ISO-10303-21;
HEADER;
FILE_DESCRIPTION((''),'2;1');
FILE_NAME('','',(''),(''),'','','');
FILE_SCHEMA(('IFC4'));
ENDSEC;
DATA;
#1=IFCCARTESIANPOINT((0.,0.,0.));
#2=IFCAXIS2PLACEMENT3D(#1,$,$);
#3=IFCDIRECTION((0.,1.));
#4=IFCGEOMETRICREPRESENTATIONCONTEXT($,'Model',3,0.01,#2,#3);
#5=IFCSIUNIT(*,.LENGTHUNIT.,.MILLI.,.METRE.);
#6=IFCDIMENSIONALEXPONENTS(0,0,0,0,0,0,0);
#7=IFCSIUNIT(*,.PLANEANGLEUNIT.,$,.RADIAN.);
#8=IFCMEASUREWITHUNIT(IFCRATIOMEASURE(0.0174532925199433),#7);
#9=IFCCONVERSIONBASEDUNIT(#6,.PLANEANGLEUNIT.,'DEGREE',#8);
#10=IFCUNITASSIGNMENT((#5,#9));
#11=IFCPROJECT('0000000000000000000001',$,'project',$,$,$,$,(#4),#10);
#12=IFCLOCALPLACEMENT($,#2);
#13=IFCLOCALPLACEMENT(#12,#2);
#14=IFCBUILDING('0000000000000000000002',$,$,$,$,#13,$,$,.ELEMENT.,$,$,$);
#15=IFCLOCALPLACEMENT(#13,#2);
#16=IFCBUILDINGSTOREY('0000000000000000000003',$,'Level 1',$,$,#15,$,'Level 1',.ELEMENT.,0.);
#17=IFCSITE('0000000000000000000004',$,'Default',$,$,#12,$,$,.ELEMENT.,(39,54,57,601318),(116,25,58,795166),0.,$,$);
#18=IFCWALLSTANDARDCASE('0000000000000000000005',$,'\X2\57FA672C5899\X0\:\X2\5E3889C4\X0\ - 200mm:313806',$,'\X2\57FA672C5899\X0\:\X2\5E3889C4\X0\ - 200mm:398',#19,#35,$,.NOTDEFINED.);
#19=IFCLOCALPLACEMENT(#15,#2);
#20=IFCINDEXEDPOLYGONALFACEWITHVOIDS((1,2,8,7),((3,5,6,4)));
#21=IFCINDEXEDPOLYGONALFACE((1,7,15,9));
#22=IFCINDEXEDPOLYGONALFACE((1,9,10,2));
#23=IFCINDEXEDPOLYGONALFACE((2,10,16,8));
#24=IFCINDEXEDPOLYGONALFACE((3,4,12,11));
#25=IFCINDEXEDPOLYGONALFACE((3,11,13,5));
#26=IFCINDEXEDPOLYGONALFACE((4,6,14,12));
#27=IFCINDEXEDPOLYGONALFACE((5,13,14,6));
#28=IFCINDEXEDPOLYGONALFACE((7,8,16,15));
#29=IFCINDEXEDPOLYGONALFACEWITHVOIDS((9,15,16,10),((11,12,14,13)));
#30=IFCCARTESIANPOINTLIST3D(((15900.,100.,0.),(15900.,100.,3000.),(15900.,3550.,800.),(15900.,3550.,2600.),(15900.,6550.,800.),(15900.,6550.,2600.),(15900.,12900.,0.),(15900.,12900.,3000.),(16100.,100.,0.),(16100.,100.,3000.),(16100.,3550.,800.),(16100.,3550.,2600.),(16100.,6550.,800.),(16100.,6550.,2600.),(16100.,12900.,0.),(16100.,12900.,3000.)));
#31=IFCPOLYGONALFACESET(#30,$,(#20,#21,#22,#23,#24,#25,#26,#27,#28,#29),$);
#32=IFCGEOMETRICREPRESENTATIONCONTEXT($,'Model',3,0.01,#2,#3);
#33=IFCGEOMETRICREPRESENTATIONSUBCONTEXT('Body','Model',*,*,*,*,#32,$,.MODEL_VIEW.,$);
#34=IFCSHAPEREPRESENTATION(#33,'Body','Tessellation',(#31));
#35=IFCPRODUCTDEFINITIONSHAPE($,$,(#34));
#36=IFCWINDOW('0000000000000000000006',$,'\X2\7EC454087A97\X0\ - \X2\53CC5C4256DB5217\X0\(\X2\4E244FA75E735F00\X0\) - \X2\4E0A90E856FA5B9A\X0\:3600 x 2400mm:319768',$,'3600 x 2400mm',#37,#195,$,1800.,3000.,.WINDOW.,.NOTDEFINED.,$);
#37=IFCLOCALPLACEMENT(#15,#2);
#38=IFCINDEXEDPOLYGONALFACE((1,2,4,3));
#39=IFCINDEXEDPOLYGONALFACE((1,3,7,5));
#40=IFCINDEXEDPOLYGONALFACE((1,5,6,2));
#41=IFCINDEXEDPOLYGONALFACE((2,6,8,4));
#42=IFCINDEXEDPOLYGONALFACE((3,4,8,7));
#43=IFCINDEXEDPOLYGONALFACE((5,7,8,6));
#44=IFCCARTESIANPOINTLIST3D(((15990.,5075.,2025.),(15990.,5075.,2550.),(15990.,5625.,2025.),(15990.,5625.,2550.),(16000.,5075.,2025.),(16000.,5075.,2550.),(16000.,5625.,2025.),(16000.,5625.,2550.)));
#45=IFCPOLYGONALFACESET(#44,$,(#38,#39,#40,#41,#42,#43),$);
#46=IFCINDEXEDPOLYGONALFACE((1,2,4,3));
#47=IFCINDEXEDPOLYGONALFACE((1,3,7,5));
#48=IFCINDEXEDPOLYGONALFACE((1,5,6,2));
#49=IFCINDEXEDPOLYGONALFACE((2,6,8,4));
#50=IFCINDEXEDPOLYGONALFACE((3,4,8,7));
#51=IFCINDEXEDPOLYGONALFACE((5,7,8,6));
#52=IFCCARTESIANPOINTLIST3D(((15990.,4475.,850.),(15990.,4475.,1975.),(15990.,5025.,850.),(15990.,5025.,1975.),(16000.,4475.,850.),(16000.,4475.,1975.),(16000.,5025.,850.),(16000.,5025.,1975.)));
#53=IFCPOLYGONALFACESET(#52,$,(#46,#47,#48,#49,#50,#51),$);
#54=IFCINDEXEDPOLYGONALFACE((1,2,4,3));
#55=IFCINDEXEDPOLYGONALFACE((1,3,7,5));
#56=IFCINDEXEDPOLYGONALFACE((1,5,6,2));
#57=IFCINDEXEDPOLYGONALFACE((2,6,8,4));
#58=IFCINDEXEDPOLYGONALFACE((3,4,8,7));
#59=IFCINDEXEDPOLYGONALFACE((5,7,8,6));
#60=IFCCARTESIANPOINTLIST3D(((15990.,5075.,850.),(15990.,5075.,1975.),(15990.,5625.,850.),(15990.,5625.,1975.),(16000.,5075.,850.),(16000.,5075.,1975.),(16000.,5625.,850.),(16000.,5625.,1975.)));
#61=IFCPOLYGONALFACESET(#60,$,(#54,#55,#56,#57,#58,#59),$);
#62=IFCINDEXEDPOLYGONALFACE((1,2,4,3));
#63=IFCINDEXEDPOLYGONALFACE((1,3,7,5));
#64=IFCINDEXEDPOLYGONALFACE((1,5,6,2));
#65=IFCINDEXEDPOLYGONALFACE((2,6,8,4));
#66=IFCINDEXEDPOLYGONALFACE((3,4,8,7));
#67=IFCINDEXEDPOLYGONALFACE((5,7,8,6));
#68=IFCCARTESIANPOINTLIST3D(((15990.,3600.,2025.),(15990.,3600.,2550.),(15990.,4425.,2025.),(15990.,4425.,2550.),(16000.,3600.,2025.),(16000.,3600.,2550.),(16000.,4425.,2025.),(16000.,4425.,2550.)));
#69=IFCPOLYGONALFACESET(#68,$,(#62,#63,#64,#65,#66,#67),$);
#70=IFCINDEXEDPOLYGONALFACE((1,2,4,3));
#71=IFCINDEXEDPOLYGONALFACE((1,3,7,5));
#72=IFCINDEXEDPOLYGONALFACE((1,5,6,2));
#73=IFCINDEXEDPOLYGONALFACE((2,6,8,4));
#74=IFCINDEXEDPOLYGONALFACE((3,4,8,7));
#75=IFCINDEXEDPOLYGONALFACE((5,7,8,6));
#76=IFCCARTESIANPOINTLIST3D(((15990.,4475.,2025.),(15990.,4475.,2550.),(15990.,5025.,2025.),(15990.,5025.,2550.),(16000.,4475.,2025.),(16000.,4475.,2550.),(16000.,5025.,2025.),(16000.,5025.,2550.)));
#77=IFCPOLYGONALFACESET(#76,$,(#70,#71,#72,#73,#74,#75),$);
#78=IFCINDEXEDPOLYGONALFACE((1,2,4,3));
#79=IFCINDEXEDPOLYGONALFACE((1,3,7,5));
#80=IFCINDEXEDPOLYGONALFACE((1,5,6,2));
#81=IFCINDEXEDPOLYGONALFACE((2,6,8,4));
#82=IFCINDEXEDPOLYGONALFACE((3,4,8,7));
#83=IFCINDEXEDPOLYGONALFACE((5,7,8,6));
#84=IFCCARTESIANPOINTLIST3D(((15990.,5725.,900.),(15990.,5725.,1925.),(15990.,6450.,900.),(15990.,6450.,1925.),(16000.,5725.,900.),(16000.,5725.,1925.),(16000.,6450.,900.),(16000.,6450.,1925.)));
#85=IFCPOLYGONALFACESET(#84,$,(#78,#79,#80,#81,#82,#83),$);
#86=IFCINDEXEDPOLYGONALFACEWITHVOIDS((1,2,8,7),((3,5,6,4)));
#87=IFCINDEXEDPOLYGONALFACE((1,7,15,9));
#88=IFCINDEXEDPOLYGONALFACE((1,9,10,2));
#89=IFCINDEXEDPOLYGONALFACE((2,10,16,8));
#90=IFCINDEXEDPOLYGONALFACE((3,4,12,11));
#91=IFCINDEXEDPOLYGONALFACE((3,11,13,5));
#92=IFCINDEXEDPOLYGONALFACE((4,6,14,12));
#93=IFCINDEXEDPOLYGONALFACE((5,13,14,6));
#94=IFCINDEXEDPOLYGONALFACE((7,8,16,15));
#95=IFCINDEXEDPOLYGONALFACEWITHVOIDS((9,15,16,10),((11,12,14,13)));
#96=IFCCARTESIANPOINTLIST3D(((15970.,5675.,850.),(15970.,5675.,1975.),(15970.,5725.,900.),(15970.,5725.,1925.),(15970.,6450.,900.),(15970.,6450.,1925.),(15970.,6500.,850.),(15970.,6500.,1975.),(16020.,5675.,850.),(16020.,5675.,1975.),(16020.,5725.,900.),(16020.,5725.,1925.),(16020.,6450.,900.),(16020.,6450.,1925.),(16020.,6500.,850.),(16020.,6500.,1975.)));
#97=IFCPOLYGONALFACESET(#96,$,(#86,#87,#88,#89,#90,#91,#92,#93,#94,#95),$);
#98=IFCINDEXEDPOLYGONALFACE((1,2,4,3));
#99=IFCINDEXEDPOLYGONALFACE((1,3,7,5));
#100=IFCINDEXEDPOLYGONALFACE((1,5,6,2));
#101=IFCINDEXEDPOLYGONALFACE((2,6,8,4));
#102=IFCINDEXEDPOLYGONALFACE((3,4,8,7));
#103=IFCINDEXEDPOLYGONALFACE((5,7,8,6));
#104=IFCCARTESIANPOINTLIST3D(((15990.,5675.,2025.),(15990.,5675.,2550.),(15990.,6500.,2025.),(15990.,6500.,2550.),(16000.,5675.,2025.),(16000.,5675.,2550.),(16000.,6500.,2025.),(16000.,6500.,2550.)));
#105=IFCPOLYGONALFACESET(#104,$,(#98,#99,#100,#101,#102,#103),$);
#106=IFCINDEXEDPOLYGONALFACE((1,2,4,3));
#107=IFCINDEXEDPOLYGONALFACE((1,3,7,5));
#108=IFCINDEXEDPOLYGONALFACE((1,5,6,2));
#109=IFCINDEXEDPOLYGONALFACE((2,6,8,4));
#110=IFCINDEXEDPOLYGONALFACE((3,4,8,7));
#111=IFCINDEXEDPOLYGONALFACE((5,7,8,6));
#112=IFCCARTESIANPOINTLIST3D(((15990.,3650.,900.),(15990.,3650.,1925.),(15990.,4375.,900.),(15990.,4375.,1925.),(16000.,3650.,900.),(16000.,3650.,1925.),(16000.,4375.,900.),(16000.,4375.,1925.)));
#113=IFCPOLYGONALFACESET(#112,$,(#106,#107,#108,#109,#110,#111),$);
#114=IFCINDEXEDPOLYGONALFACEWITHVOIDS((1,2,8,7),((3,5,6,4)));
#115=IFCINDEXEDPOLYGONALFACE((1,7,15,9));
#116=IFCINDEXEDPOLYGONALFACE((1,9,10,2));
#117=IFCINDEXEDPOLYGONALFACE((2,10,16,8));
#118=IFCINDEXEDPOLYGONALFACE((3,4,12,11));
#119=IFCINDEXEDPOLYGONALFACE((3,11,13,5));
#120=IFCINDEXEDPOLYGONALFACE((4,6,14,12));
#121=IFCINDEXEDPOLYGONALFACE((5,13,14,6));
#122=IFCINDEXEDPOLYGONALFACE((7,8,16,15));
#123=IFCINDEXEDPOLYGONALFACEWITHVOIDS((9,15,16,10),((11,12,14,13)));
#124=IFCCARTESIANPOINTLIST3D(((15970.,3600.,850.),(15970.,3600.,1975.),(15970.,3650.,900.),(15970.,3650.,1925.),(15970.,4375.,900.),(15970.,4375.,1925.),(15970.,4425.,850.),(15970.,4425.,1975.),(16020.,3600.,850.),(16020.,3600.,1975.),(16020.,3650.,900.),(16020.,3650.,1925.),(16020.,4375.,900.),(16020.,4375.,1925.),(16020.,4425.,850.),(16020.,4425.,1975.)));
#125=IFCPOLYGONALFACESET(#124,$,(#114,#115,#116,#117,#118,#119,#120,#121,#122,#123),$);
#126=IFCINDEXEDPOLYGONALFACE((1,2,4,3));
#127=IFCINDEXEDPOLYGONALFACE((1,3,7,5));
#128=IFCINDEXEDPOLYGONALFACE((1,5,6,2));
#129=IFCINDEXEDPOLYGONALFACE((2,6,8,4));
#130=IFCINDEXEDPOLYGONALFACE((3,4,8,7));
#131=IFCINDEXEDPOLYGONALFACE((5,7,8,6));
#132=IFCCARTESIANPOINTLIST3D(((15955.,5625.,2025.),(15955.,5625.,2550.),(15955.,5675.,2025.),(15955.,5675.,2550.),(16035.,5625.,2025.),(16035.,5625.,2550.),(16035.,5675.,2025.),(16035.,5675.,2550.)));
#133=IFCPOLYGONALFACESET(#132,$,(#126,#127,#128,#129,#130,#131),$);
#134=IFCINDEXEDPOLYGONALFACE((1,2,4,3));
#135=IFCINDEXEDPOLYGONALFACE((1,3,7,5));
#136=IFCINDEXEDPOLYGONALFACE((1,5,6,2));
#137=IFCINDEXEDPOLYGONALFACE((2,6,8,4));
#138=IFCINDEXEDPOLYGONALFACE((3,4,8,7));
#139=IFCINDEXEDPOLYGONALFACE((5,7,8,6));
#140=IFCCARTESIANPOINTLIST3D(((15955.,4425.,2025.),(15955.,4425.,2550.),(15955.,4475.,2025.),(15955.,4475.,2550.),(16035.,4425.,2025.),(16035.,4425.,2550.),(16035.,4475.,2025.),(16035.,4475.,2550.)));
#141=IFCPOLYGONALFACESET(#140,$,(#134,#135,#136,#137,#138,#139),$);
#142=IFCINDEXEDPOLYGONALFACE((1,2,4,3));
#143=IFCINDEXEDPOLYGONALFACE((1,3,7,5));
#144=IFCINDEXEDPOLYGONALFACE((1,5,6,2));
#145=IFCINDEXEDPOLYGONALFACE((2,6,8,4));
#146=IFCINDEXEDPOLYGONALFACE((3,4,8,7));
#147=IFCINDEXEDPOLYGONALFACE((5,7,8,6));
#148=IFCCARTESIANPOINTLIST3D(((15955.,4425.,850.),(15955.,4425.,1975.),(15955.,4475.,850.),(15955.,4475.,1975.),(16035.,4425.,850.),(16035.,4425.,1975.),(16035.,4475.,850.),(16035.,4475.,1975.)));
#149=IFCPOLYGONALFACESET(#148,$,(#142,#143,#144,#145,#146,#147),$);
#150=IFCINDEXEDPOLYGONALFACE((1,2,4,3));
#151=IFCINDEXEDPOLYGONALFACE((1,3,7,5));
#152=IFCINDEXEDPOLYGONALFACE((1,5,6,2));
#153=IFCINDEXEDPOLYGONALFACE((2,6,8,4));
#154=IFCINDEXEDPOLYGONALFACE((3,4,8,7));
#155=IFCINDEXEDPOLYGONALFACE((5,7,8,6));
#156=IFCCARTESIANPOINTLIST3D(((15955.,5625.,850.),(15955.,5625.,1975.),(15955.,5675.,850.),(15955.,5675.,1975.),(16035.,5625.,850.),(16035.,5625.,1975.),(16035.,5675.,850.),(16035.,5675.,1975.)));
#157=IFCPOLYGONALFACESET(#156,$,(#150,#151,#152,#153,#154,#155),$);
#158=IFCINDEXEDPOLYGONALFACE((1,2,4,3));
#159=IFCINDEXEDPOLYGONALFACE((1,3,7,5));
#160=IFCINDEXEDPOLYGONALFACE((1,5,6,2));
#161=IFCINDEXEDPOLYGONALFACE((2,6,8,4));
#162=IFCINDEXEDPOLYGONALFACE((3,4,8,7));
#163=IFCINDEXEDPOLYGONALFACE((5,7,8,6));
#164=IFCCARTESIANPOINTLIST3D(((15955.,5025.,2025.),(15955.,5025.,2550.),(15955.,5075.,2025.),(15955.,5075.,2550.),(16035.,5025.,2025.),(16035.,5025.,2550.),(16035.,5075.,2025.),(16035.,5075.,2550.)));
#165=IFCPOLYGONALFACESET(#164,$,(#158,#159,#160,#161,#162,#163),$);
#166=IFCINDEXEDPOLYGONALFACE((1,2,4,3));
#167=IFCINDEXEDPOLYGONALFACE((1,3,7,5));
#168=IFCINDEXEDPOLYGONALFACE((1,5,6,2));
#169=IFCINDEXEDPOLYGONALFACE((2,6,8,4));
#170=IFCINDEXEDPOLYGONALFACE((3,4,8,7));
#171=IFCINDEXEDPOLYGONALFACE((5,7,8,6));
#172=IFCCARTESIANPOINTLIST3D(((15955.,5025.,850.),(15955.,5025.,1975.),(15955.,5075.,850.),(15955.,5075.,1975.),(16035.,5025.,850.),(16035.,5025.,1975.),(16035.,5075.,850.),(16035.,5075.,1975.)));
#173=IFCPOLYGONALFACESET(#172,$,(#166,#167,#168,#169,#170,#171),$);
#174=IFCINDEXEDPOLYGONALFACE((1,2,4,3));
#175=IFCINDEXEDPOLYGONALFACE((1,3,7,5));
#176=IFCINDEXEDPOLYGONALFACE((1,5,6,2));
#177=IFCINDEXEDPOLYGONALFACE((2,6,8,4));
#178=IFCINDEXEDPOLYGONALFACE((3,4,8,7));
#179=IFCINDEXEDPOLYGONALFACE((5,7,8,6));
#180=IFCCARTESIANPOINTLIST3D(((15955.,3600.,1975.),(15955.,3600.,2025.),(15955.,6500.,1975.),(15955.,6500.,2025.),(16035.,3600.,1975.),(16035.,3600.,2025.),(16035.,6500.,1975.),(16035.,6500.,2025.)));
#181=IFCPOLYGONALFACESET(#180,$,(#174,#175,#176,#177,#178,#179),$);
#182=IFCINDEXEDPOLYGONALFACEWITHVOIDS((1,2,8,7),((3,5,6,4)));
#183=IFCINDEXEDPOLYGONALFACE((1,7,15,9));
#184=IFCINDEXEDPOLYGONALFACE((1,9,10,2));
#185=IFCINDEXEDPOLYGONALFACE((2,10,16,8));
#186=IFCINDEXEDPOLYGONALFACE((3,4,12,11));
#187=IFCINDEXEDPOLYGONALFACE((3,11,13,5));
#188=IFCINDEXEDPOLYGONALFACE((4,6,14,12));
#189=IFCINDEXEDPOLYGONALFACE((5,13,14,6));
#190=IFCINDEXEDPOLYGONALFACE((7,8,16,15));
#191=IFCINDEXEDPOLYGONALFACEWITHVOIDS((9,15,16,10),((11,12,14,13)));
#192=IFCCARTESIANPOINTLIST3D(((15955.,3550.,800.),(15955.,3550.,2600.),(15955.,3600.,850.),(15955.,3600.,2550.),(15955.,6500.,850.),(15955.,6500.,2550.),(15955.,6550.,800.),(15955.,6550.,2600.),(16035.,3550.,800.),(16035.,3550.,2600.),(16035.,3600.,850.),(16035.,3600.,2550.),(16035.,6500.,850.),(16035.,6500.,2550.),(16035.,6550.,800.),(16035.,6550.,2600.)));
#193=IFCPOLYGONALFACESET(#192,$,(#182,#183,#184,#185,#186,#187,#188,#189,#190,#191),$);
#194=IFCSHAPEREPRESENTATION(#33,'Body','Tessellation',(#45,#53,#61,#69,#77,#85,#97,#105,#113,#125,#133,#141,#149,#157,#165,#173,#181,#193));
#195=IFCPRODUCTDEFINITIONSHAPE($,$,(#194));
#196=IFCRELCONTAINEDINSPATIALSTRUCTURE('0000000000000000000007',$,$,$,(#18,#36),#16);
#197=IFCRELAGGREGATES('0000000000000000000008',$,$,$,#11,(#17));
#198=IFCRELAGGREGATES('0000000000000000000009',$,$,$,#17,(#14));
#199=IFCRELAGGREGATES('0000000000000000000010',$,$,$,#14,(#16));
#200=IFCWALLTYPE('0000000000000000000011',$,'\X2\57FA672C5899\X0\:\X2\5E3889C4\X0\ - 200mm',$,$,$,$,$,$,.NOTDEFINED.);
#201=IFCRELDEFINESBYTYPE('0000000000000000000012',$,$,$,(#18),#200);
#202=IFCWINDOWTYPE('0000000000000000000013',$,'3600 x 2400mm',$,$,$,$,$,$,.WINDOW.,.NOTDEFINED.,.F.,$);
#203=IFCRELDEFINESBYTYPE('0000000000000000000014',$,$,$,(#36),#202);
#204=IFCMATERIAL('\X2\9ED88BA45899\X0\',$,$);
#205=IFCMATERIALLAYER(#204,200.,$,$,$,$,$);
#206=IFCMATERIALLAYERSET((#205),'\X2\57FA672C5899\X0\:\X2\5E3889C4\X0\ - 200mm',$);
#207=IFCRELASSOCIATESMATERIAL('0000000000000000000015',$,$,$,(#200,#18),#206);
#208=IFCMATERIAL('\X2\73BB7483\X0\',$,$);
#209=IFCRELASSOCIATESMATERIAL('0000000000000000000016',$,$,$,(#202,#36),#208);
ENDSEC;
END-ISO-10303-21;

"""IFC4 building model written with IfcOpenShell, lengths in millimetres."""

from ifc_helpers import new_model, entity, si_unit, converted_unit, direction, frame, frame_2d, origin, origin_2d_with_axis, place, context, subcontext, project, spatial, polyline, rectangle, outline, extrude, source, transform, mapped, material, layer, layer_set, layer_usage, type_object, type_shapes, element, fill, save


model = new_model("IFC4")

# Units and contexts
model_context_1 = context("Model", 3, precision=0.01, world=origin(), true_north=direction((0.0, 1.0)))
model_context_2 = context("Model", 3, precision=0.01, world=origin(), true_north=direction((0.0, 1.0)))
body_context = subcontext(model_context_2, "Body", "Model", "MODEL_VIEW")
ifc_project = project(units=[si_unit("LENGTHUNIT", "METRE", prefix="MILLI"), converted_unit("PLANEANGLEUNIT", "DEGREE", entity("IfcRatioMeasure", 0.0174532925199433), si_unit("PLANEANGLEUNIT", "RADIAN"), dimensions=[0, 0, 0, 0, 0, 0, 0])], contexts=[model_context_1])

# Site, building, storey
site_placement = place(None, origin())
site = spatial("IfcSite", under=ifc_project, at=site_placement, Name="Default", CompositionType="ELEMENT", RefLatitude=(39, 54, 57, 601318), RefLongitude=(116, 25, 58, 795166), RefElevation=0.0)
building_placement = place(site_placement, origin())
building = spatial("IfcBuilding", under=site, at=building_placement, CompositionType="ELEMENT")
storey_placement = place(building_placement, origin())
storey = spatial("IfcBuildingStorey", under=building, at=storey_placement, Name="Level 1", LongName="Level 1", CompositionType="ELEMENT", Elevation=0.0)

# Shared definitions
ifc_material_1 = material(Name="默认墙")
ifc_layer = layer(ifc_material_1, 200.0)
ifc_layer_set = layer_set([ifc_layer], Name="基本墙:常规 - 200mm")
wall_type = type_object("IfcWallType", Name="基本墙:常规 - 200mm", PredefinedType="NOTDEFINED", material=ifc_layer_set)
ifc_material_2 = material(Name="玻璃")
window_type_1 = type_object("IfcWindowType", Name="3600 x 2400mm", ParameterTakesPrecedence=False, PartitioningType="NOTDEFINED", PredefinedType="WINDOW", material=ifc_material_2)
shared_shape_1 = source(origin(), body_context, "Body", "SweptSolid", [
    extrude(rectangle(XDim=10.0, YDim=550.0, at=origin_2d_with_axis()), frame((1200.0, 95.0, 1225.0), z_axis=(0.0, 0.0, 1.0), x_axis=(0.0, 1.0, 0.0)), (0.0, 0.0, 1.0), 525.0),
    extrude(rectangle(XDim=10.0, YDim=550.0, at=origin_2d_with_axis()), frame((1800.0, 95.0, 50.0), z_axis=(0.0, 0.0, 1.0), x_axis=(0.0, 1.0, 0.0)), (0.0, 0.0, 1.0), 1125.0),
    extrude(rectangle(XDim=10.0, YDim=550.0, at=origin_2d_with_axis()), frame((1200.0, 95.0, 50.0), z_axis=(0.0, 0.0, 1.0), x_axis=(0.0, 1.0, 0.0)), (0.0, 0.0, 1.0), 1125.0),
    extrude(rectangle(XDim=10.0, YDim=825.0, at=origin_2d_with_axis()), frame((2537.5, 95.0, 1225.0), z_axis=(0.0, 0.0, 1.0), x_axis=(0.0, 1.0, 0.0)), (0.0, 0.0, 1.0), 525.0),
    extrude(rectangle(XDim=10.0, YDim=550.0, at=origin_2d_with_axis()), frame((1800.0, 95.0, 1225.0), z_axis=(0.0, 0.0, 1.0), x_axis=(0.0, 1.0, 0.0)), (0.0, 0.0, 1.0), 525.0),
    extrude(rectangle(XDim=10.0, YDim=725.0, at=origin_2d_with_axis()), frame((462.5, 95.0, 100.0), z_axis=(0.0, 0.0, 1.0), x_axis=(0.0, 1.0, 0.0)), (0.0, 0.0, 1.0), 1025.0),
    extrude(outline(polyline([(-562.5, -412.5), (562.5, -412.5), (562.5, 412.5), (-562.5, 412.5), (-562.5, -412.5)]), holes=[polyline([(512.5, -362.5), (-512.5, -362.5), (-512.5, 362.5), (512.5, 362.5), (512.5, -362.5)])]), frame((462.5, 70.0, 612.5), z_axis=(0.0, 1.0, 0.0), x_axis=(0.0, 0.0, -1.0)), (0.0, 0.0, 1.0), 50.0),
    extrude(rectangle(XDim=10.0, YDim=825.0, at=origin_2d_with_axis()), frame((462.5, 95.0, 1225.0), z_axis=(0.0, 0.0, 1.0), x_axis=(0.0, 1.0, 0.0)), (0.0, 0.0, 1.0), 525.0),
    extrude(rectangle(XDim=10.0, YDim=725.0, at=origin_2d_with_axis()), frame((2537.5, 95.0, 100.0), z_axis=(0.0, 0.0, 1.0), x_axis=(0.0, 1.0, 0.0)), (0.0, 0.0, 1.0), 1025.0),
    extrude(outline(polyline([(-562.5, -412.5), (562.5, -412.5), (562.5, 412.5), (-562.5, 412.5), (-562.5, -412.5)]), holes=[polyline([(512.5, -362.5), (-512.5, -362.5), (-512.5, 362.5), (512.5, 362.5), (512.5, -362.5)])]), frame((2537.5, 70.0, 612.5), z_axis=(0.0, 1.0, 0.0), x_axis=(0.0, 0.0, -1.0)), (0.0, 0.0, 1.0), 50.0),
    extrude(rectangle(XDim=80.0, YDim=50.0, at=origin_2d_with_axis()), frame((900.0, 95.0, 1225.0), z_axis=(0.0, 0.0, 1.0), x_axis=(0.0, -1.0, 0.0)), (0.0, 0.0, 1.0), 525.0),
    extrude(rectangle(XDim=80.0, YDim=50.0, at=origin_2d_with_axis()), frame((2100.0, 95.0, 1225.0), z_axis=(0.0, 0.0, 1.0), x_axis=(0.0, -1.0, 0.0)), (0.0, 0.0, 1.0), 525.0),
    extrude(rectangle(XDim=80.0, YDim=50.0, at=origin_2d_with_axis()), frame((2100.0, 95.0, 50.0), z_axis=(0.0, 0.0, 1.0), x_axis=(0.0, -1.0, 0.0)), (0.0, 0.0, 1.0), 1125.0),
    extrude(rectangle(XDim=80.0, YDim=50.0, at=origin_2d_with_axis()), frame((900.0, 95.0, 50.0), z_axis=(0.0, 0.0, 1.0), x_axis=(0.0, -1.0, 0.0)), (0.0, 0.0, 1.0), 1125.0),
    extrude(rectangle(XDim=80.0, YDim=50.0, at=origin_2d_with_axis()), frame((1500.0, 95.0, 1225.0), z_axis=(0.0, 0.0, 1.0), x_axis=(0.0, -1.0, 0.0)), (0.0, 0.0, 1.0), 525.0),
    extrude(rectangle(XDim=80.0, YDim=50.0, at=origin_2d_with_axis()), frame((1500.0, 95.0, 50.0), z_axis=(0.0, 0.0, 1.0), x_axis=(0.0, -1.0, 0.0)), (0.0, 0.0, 1.0), 1125.0),
    extrude(rectangle(XDim=80.0, YDim=2900.0, at=origin_2d_with_axis()), frame((1500.0, 95.0, 1175.0), z_axis=(0.0, 0.0, 1.0), x_axis=(0.0, -1.0, 0.0)), (0.0, 0.0, 1.0), 50.0),
    extrude(outline(polyline([(-1500.0, -900.0), (1500.0, -900.0), (1500.0, 900.0), (-1500.0, 900.0), (-1500.0, -900.0)]), holes=[polyline([(1450.0, -850.0), (-1450.0, -850.0), (-1450.0, 850.0), (1450.0, 850.0), (1450.0, -850.0)])]), frame((1500.0, 55.0, 900.0), z_axis=(0.0, 1.0, 0.0), x_axis=(1.0, 0.0, 0.0)), (0.0, 0.0, 1.0), 80.0),
])
type_shapes(window_type_1, [shared_shape_1])

# Wall, opening, window
ifc_layer_usage_1 = layer_usage(ifc_layer_set, "AXIS2", "NEGATIVE", 100.0)
wall_1_placement = place(storey_placement, frame((16000.0, 12900.0, 0.0), z_axis=(0.0, 0.0, 1.0), x_axis=(0.0, -1.0, 0.0)))
wall_1 = element("IfcWallStandardCase", 1, at=wall_1_placement, inside=storey, type_object=wall_type, material=ifc_layer_usage_1, Name="基本墙:常规 - 200mm:313806", ObjectType="基本墙:常规 - 200mm:398", PredefinedType="NOTDEFINED", context=body_context, shape_type="SweptSolid", body=[
    extrude(rectangle(XDim=12800.0, YDim=200.0, at=frame_2d((6400.0, 0.0), x_axis=(-1.0, 0.0))), origin(), (0.0, 0.0, 1.0), 3000.0),
])
opening_1_placement = place(wall_1_placement, frame((6350.0, -100.0, 800.0)))
opening_1 = element("IfcOpeningElement", 2, at=opening_1_placement, cuts=wall_1, ObjectType="Opening", PredefinedType="OPENING", context=body_context, shape_type="SweptSolid", body=[
    extrude(rectangle(XDim=1800.0, YDim=3000.0, at=frame_2d((900.0, 1500.0), x_axis=(1.0, 0.0))), frame((0.0, 0.0, 0.0), z_axis=(0.0, 1.0, 0.0), x_axis=(0.0, 0.0, 1.0)), (0.0, 0.0, 1.0), 200.0),
])
window_1_placement = place(opening_1_placement, origin())
window_1 = element("IfcWindow", 3, at=window_1_placement, inside=storey, type_object=window_type_1, material=ifc_material_2, Name="组合窗 - 双层四列(两侧平开) - 上部固定:3600 x 2400mm:319768", ObjectType="3600 x 2400mm", OverallHeight=1800.0, OverallWidth=3000.0, PartitioningType="NOTDEFINED", PredefinedType="WINDOW", context=body_context, shape_type="MappedRepresentation", body=[
    mapped(shared_shape_1, transform((0.0, 0.0, 0.0), scale=1.0)),
])
fill(opening_1, window_1)

save(model, "model.ifc")
